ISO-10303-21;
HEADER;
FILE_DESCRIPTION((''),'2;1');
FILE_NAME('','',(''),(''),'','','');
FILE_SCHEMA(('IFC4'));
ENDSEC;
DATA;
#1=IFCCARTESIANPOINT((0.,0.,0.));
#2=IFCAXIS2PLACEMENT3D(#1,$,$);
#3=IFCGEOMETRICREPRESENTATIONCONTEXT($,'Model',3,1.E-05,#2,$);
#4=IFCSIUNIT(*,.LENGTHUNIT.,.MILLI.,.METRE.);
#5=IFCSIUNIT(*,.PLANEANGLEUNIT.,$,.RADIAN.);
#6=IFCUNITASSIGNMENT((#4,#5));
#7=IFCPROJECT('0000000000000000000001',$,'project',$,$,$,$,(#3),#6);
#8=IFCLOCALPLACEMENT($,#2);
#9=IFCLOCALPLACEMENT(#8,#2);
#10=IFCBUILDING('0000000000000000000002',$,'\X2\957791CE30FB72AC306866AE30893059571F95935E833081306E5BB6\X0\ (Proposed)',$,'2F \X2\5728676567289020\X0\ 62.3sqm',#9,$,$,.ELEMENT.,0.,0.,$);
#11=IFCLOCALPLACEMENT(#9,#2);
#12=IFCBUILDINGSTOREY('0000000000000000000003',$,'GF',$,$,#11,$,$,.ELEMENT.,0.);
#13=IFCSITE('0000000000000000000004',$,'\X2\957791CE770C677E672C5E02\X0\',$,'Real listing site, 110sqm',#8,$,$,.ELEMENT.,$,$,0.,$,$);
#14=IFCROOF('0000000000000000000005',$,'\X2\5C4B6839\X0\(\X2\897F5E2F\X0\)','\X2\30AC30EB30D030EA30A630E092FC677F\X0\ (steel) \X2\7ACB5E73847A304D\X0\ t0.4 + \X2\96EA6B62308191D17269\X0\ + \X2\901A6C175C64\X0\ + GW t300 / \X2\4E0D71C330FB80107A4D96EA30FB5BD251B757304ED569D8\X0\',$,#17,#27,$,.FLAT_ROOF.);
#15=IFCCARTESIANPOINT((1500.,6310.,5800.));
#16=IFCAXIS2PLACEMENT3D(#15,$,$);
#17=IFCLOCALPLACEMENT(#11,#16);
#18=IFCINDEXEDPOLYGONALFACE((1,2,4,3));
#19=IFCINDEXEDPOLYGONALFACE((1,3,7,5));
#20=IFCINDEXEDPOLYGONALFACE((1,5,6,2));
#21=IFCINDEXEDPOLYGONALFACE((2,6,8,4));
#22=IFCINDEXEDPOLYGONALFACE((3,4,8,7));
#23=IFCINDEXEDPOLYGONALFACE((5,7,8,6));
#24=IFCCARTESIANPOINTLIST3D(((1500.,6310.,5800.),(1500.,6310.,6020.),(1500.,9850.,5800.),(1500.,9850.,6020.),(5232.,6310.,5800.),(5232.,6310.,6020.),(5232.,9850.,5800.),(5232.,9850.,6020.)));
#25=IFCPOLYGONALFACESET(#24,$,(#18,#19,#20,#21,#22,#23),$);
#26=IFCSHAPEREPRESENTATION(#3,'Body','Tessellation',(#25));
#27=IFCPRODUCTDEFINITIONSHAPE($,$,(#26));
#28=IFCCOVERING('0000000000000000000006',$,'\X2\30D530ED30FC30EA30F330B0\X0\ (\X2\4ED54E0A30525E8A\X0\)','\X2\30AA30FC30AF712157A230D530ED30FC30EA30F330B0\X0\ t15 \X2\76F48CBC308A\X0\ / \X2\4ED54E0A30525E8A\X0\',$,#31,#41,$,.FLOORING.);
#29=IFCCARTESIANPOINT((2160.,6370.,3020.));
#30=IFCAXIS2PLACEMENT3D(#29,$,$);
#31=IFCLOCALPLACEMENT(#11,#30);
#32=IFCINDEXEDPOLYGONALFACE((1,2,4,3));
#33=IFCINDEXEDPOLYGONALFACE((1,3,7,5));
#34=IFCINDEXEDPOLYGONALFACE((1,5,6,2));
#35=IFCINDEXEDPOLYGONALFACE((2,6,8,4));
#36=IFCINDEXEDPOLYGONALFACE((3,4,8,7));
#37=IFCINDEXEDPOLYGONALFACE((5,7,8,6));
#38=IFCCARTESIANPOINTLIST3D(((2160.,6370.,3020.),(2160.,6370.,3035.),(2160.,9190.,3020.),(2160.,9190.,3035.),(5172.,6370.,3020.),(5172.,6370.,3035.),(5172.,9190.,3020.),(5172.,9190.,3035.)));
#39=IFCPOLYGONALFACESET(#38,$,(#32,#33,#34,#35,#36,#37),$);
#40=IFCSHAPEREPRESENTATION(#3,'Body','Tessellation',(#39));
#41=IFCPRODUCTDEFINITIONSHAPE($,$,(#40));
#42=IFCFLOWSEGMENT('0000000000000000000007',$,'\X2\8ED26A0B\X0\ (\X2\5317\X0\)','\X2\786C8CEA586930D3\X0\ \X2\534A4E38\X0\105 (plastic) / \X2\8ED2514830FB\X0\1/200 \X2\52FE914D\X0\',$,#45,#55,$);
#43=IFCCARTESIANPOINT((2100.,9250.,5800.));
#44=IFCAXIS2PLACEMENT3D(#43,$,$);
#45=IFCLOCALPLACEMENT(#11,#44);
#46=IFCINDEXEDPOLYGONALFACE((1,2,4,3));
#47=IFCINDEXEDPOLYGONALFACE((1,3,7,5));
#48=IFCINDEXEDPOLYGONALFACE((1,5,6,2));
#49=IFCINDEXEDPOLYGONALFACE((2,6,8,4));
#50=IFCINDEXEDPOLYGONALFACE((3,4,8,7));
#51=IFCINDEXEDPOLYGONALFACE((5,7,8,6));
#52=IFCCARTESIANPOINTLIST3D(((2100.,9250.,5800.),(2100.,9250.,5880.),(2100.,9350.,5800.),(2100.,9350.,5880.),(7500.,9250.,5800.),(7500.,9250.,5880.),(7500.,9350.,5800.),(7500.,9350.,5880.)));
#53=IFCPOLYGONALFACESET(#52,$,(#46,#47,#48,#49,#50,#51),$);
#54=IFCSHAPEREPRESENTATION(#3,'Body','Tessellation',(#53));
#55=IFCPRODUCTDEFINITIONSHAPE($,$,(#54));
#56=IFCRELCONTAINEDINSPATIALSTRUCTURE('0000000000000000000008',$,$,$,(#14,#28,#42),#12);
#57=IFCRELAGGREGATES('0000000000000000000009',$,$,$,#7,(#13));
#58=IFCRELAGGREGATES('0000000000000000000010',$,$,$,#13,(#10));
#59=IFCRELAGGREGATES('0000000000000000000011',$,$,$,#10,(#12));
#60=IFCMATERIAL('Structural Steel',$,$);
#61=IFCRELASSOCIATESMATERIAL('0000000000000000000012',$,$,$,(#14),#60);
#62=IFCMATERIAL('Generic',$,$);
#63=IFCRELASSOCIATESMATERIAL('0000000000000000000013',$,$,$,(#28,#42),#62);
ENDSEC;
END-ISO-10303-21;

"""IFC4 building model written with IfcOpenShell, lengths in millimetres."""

from ifc_helpers import new_model, si_unit, frame, frame_2d, origin, place, context, project, spatial, rectangle, extrude, material, element, save


model = new_model("IFC4")

# Units and contexts
model_context = context("Model", 3, precision=1e-05, world=origin())
ifc_project = project(units=[si_unit("LENGTHUNIT", "METRE", prefix="MILLI"), si_unit("PLANEANGLEUNIT", "RADIAN")], contexts=[model_context])

# Site, building, storey
site_placement = place(None, origin())
site = spatial("IfcSite", under=ifc_project, at=site_placement, Name="長野県松本市", ObjectType="Real listing site, 110sqm", CompositionType="ELEMENT", RefElevation=0.0)
building_placement = place(site_placement, origin())
building = spatial("IfcBuilding", under=site, at=building_placement, Name="長野・犬と暮らす土間広めの家 (Proposed)", ObjectType="2F 在来木造 62.3sqm", CompositionType="ELEMENT", ElevationOfRefHeight=0.0, ElevationOfTerrain=0.0)
storey_placement = place(building_placement, origin())
storey = spatial("IfcBuildingStorey", under=building, at=storey_placement, Name="GF", CompositionType="ELEMENT", Elevation=0.0)

# Roof
ifc_material_1 = material(Name="Structural Steel")
for number, where, name in (
    (1, (1500.0, 6310.0, 5800.0), "屋根(西帯)"),
):
    element("IfcRoof", number, at=place(storey_placement, frame(where)), inside=storey, material=ifc_material_1, Name=name, Description="ガルバリウム鋼板 (steel) 立平葺き t0.4 + 雪止め金物 + 通気層 + GW t300 / 不燃・耐積雪・寒冷地仕様", PredefinedType="FLAT_ROOF", context=model_context, shape_type="SweptSolid", body=[
        extrude(rectangle(XDim=3732.0, YDim=3540.0, at=frame_2d((1866.0, 1770.0))), frame((1500.0, 6310.0, 5800.0)), (0.0, 0.0, 1.0), 220.0),
    ])

# Covering
ifc_material_2 = material(Name="Generic")
covering_placement = place(storey_placement, frame((2160.0, 6370.0, 3020.0)))
element("IfcCovering", 2, at=covering_placement, inside=storey, material=ifc_material_2, Name="フローリング (仕上げ床)", Description="オーク無垢フローリング t15 直貼り / 仕上げ床", PredefinedType="FLOORING", context=model_context, shape_type="SweptSolid", body=[
    extrude(rectangle(XDim=3012.0, YDim=2820.0, at=frame_2d((1506.0, 1410.0))), frame((2160.0, 6370.0, 3020.0)), (0.0, 0.0, 1.0), 15.0),
])

# Flow segment
flow_segment_placement = place(storey_placement, frame((2100.0, 9250.0, 5800.0)))
element("IfcFlowSegment", 3, at=flow_segment_placement, inside=storey, material=ifc_material_2, Name="軒樋 (北)", Description="硬質塩ビ 半丸105 (plastic) / 軒先・1/200 勾配", context=model_context, shape_type="SweptSolid", body=[
    extrude(rectangle(XDim=5400.0, YDim=100.0, at=frame_2d((2700.0, 50.0))), frame((2100.0, 9250.0, 5800.0)), (0.0, 0.0, 1.0), 80.0),
])

save(model, "model.ifc")
